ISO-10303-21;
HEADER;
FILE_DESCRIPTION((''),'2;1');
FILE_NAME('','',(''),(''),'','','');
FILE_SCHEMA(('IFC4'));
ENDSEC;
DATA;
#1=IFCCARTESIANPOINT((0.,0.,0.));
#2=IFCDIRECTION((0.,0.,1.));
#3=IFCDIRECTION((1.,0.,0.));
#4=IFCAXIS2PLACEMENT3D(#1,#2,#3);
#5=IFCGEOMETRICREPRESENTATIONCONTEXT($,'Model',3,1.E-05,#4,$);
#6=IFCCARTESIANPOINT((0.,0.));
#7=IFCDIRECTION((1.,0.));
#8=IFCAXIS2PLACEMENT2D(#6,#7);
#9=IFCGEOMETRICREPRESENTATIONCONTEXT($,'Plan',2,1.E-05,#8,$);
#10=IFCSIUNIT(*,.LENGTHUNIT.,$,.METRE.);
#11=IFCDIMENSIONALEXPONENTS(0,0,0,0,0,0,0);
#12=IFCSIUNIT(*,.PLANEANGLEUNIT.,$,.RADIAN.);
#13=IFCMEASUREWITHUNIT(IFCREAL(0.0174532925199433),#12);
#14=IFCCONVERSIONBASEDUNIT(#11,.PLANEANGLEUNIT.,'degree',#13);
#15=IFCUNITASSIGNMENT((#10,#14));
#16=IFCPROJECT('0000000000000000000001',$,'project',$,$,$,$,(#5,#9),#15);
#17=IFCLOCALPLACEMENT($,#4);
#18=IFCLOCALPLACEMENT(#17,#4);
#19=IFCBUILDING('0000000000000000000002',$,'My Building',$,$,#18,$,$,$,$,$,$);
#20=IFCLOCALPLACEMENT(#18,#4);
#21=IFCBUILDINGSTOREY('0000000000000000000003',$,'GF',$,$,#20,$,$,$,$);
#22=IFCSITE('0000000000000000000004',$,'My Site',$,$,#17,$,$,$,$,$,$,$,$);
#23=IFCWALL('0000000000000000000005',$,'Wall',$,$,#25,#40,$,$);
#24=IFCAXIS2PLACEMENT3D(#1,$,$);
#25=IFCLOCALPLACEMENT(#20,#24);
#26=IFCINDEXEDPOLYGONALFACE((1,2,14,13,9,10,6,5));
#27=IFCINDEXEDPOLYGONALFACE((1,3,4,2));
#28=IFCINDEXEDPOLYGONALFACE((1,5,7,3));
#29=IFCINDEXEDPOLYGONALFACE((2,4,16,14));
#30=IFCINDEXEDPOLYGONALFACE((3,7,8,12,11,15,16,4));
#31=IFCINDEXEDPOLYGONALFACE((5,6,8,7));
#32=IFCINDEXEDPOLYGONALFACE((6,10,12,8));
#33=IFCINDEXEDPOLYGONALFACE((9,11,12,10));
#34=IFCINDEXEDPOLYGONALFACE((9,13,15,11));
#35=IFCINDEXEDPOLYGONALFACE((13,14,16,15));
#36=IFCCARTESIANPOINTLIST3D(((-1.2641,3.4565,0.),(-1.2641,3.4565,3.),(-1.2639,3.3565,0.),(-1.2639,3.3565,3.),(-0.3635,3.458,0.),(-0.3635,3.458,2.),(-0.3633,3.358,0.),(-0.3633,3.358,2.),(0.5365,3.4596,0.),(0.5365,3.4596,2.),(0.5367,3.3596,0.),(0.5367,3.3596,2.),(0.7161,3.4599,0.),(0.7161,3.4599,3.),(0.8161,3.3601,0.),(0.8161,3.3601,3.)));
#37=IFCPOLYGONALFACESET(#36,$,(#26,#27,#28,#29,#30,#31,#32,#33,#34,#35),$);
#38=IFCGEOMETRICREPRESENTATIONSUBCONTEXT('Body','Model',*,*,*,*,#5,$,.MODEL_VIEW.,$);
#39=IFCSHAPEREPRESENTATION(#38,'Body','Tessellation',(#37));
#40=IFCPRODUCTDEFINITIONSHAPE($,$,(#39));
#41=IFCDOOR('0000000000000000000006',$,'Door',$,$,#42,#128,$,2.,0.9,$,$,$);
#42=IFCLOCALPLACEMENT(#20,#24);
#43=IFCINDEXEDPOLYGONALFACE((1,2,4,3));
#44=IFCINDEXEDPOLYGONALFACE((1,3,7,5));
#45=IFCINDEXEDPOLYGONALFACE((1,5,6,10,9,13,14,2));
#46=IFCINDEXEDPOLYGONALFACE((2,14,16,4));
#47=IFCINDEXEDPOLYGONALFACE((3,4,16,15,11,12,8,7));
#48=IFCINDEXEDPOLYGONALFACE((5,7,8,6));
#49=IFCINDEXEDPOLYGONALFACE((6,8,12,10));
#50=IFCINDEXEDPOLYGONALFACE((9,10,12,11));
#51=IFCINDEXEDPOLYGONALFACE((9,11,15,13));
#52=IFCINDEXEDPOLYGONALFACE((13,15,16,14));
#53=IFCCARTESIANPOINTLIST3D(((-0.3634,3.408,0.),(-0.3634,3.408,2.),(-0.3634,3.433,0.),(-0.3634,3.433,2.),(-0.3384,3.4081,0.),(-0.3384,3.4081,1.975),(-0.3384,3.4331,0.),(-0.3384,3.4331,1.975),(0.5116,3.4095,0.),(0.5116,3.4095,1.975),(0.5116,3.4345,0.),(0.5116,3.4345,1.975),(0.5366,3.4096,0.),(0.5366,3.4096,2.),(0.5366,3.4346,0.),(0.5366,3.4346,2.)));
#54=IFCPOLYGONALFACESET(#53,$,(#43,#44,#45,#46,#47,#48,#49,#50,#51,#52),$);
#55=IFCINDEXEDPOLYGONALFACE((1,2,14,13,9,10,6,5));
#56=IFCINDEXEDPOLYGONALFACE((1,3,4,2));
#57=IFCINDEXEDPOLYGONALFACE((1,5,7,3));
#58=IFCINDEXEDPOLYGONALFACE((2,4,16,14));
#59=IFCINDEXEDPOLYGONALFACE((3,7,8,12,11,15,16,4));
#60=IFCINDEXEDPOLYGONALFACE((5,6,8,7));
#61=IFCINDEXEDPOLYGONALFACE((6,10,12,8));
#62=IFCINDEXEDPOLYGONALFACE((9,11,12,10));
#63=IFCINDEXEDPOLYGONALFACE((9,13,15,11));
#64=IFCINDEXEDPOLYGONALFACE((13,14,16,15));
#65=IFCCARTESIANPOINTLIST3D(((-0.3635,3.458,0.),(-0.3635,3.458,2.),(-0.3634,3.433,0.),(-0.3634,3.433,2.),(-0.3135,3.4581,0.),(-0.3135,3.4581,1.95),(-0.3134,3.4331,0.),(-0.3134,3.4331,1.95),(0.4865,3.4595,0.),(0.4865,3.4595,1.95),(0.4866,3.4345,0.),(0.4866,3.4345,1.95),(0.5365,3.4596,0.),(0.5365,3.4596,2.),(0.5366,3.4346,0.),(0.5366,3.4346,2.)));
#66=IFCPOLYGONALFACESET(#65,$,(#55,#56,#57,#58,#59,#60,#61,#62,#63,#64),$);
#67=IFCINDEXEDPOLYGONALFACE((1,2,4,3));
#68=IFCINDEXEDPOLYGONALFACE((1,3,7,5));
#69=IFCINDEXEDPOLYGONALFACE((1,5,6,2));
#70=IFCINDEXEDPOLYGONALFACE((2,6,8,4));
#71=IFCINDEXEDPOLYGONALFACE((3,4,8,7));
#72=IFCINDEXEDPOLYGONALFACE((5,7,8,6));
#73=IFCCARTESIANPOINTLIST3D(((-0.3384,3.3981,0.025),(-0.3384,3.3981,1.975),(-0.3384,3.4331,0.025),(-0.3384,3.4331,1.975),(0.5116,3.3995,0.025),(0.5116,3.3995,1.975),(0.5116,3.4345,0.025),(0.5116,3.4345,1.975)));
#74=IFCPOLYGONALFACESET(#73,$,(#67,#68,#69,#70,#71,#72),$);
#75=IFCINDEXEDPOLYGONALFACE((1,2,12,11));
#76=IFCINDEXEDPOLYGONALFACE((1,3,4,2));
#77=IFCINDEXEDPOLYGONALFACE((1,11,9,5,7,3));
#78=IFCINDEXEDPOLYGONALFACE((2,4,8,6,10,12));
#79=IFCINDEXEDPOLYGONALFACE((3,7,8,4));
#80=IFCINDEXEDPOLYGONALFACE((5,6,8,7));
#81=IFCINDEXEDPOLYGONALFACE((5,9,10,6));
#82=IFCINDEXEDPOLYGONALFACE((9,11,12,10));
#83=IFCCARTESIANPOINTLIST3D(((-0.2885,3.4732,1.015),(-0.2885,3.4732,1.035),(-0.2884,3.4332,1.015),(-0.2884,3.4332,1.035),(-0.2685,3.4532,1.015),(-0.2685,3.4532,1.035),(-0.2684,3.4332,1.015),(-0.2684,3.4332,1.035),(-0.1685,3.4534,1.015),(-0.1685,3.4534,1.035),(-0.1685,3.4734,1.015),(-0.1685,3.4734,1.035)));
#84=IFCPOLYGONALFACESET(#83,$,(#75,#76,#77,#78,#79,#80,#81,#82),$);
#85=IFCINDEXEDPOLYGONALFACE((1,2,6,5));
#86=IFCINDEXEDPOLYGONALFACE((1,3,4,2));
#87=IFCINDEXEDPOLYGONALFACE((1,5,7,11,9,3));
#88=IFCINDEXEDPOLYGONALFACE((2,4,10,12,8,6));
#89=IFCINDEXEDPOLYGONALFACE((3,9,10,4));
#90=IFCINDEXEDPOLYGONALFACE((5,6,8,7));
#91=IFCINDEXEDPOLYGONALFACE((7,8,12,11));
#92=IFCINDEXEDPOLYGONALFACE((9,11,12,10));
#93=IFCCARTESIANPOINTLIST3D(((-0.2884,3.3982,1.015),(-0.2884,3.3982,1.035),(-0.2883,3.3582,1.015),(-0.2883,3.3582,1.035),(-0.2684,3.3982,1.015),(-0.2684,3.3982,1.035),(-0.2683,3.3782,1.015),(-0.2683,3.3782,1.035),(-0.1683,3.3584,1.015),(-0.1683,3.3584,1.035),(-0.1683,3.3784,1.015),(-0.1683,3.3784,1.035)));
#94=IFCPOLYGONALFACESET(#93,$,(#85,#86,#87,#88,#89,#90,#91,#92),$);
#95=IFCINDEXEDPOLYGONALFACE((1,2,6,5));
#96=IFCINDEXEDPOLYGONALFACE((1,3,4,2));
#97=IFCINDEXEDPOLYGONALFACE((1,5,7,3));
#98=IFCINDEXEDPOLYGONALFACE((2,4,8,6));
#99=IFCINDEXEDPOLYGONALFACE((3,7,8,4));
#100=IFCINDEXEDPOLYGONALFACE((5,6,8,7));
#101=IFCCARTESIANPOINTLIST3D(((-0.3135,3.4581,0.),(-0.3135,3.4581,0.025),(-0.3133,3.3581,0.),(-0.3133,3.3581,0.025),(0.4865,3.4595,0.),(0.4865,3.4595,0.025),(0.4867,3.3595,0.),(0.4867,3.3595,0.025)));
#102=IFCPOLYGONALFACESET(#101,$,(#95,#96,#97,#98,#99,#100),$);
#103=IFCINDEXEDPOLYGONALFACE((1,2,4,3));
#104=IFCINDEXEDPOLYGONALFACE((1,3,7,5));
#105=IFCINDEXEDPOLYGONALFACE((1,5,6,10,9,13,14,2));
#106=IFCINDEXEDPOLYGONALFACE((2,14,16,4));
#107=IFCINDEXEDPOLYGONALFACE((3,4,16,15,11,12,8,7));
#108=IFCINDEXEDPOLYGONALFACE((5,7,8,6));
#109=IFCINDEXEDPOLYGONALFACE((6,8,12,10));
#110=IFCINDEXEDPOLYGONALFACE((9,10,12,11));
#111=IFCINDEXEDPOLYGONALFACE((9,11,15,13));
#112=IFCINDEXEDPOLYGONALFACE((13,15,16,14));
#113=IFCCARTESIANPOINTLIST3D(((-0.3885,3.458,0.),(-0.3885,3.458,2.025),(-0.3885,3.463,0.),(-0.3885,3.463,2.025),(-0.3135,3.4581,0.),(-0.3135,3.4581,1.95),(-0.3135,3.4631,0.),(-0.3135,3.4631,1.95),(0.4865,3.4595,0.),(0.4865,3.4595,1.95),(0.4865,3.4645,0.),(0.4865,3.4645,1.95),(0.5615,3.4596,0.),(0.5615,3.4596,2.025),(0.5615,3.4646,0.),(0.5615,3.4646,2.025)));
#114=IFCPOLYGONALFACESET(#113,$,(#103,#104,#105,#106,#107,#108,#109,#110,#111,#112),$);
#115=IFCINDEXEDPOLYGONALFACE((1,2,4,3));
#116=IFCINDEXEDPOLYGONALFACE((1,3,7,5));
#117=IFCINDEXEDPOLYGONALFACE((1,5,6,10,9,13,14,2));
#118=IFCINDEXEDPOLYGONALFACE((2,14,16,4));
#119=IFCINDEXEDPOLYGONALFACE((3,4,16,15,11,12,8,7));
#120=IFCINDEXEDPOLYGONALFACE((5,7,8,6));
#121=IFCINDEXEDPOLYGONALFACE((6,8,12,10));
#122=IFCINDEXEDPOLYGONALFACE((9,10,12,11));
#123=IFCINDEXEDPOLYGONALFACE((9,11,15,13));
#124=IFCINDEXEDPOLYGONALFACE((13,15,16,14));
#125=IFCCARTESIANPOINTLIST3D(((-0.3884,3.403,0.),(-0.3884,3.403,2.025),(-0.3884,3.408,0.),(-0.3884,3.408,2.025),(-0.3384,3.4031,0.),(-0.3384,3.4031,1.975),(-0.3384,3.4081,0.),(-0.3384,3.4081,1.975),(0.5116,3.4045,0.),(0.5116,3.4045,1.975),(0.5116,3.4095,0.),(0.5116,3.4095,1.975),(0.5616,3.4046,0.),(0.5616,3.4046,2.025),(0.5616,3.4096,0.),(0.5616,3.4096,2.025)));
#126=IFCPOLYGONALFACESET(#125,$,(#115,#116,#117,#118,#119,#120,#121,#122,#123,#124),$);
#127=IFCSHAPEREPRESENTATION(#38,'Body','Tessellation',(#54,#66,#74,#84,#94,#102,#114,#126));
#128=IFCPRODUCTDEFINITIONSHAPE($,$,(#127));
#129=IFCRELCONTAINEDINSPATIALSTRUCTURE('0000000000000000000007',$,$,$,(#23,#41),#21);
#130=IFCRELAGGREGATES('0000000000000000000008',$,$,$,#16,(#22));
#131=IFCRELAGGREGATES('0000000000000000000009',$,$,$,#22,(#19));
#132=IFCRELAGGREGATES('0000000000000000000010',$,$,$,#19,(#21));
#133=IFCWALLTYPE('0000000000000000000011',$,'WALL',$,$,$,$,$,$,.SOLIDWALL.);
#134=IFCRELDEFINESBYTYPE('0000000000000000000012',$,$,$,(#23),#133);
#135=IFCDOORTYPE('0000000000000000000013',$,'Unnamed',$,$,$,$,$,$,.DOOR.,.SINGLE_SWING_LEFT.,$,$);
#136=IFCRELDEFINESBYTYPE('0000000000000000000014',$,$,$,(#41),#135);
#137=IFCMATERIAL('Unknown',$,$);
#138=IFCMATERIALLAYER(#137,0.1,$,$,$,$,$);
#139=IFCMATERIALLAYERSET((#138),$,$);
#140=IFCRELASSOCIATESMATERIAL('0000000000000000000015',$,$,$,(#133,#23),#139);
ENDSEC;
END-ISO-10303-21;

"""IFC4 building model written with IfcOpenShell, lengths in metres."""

from ifc_helpers import new_model, entity, si_unit, converted_unit, frame, origin_with_axes, origin_2d_with_axis, place, context, subcontext, project, spatial, line, indexed_curve, outline, extrude, shape, source, transform, mapped, material, layer, layer_set, layer_usage, type_object, type_shapes, element, fill, save


model = new_model("IFC4")

# Units and contexts
model_context = context("Model", 3, precision=1e-05, world=origin_with_axes())
plan_context = context("Plan", 2, precision=1e-05, world=origin_2d_with_axis())
body_context_1 = subcontext(model_context, "Body", "Model", "MODEL_VIEW")
body_context_2 = subcontext(plan_context, "Body", "Plan", "PLAN_VIEW")
ifc_project = project(units=[si_unit("LENGTHUNIT", "METRE"), converted_unit("PLANEANGLEUNIT", "degree", entity("IfcReal", 0.0174532925199433), si_unit("PLANEANGLEUNIT", "RADIAN"), dimensions=[0, 0, 0, 0, 0, 0, 0])], contexts=[model_context, plan_context])

# Site, building, storey
site_placement = place(None, origin_with_axes())
site = spatial("IfcSite", under=ifc_project, at=site_placement, Name="My Site")
building_placement = place(site_placement, origin_with_axes())
building = spatial("IfcBuilding", under=site, at=building_placement, Name="My Building")
storey_placement = place(building_placement, origin_with_axes())
storey = spatial("IfcBuildingStorey", under=building, at=storey_placement, Name="GF")

# Shared definitions
ifc_material = material(Name="Unknown")

# Shared definitions
ifc_layer_1 = layer(ifc_material, 0.1)
ifc_layer_set_1 = layer_set([ifc_layer_1])
wall_type = type_object("IfcWallType", Name="WALL", PredefinedType="SOLIDWALL", material=ifc_layer_set_1)
shared_shape_1 = source(origin_with_axes(), body_context_1, "Body", "SweptSolid", [
    extrude(outline(indexed_curve([(0.0, 0.0), (0.9, 0.0), (0.9, 2.0), (0.0, 2.0)], segments=[line(1, 2, 3, 4, 1)])), frame((0.0, -0.6, 0.0), z_axis=(0.0, -1.0, 0.0), x_axis=(1.0, 0.0, 0.0)), (0.0, 0.0, -1.0), 1.2),
])
door_type = type_object("IfcDoorType", Name="Unnamed", OperationType="SINGLE_SWING_LEFT", PredefinedType="DOOR")
shared_shape_2 = source(origin_with_axes(), body_context_1, "Body", "SweptSolid", [
    extrude(outline(indexed_curve([(0.0, 0.0), (0.0, 2.0), (0.9, 2.0), (0.9, 0.0), (0.875, 0.0), (0.875, 1.975), (0.025, 1.975), (0.025, 0.0)], segments=[line(1, 2, 3, 4, 5, 6, 7, 8, 1)])), frame((0.0, 0.025, 0.0), z_axis=(0.0, -1.0, 0.0), x_axis=(1.0, 0.0, 0.0)), (0.0, 0.0, -1.0), 0.025),
    extrude(outline(indexed_curve([(0.0, 0.0), (0.0, 2.0), (0.9, 2.0), (0.9, 0.0), (0.85, 0.0), (0.85, 1.95), (0.05, 1.95), (0.05, 0.0)], segments=[line(1, 2, 3, 4, 5, 6, 7, 8, 1)])), frame((0.0, 0.0, 0.0), z_axis=(0.0, -1.0, 0.0), x_axis=(1.0, 0.0, 0.0)), (0.0, 0.0, -1.0), 0.025),
    extrude(outline(indexed_curve([(0.0, 0.0), (0.85, 0.0), (0.85, 0.035), (0.0, 0.035)], segments=[line(1, 2, 3, 4, 1)])), frame((0.025, 0.025, 0.025), z_axis=(0.0, 0.0, 1.0), x_axis=(1.0, 0.0, 0.0)), (0.0, 0.0, 1.0), 1.95),
    extrude(outline(indexed_curve([(0.0, 0.0), (0.0, -0.04), (-0.12, -0.04), (-0.12, -0.02), (-0.02, -0.02), (-0.02, 0.0)], segments=[line(1, 2, 3, 4, 5, 6, 1)])), frame((0.825, 0.025, 1.015), z_axis=(0.0, 0.0, 1.0), x_axis=(1.0, 0.0, 0.0)), (0.0, 0.0, 1.0), 0.02),
    extrude(outline(indexed_curve([(0.0, 0.0), (0.0, 0.04), (-0.12, 0.04), (-0.12, 0.02), (-0.02, 0.02), (-0.02, 0.0)], segments=[line(1, 2, 3, 4, 5, 6, 1)])), frame((0.825, 0.06, 1.015), z_axis=(0.0, 0.0, 1.0), x_axis=(1.0, 0.0, 0.0)), (0.0, 0.0, 1.0), 0.02),
    extrude(outline(indexed_curve([(0.0, 0.0), (0.8, 0.0), (0.8, 0.1), (0.0, 0.1)], segments=[line(1, 2, 3, 4, 1)])), frame((0.05, 0.0, 0.0), z_axis=(0.0, 0.0, 1.0), x_axis=(1.0, 0.0, 0.0)), (0.0, 0.0, 1.0), 0.025),
    extrude(outline(indexed_curve([(0.0, 0.0), (0.0, 2.025), (0.95, 2.025), (0.95, 0.0), (0.875, 0.0), (0.875, 1.95), (0.075, 1.95), (0.075, 0.0)], segments=[line(1, 2, 3, 4, 5, 6, 7, 8, 1)])), frame((-0.025, -0.005, 0.0), z_axis=(0.0, -1.0, 0.0), x_axis=(1.0, 0.0, 0.0)), (0.0, 0.0, -1.0), 0.005),
    extrude(outline(indexed_curve([(0.0, 0.0), (0.0, 2.025), (0.95, 2.025), (0.95, 0.0), (0.9, 0.0), (0.9, 1.975), (0.05, 1.975), (0.05, 0.0)], segments=[line(1, 2, 3, 4, 5, 6, 7, 8, 1)])), frame((-0.025, 0.05, 0.0), z_axis=(0.0, -1.0, 0.0), x_axis=(1.0, 0.0, 0.0)), (0.0, 0.0, -1.0), 0.005),
])
shared_shape_3 = source(origin_with_axes(), body_context_2, "Body", "Curve2D", [
    entity("IfcIndexedPolyCurve", entity("IfcCartesianPointList2D", [[0.0, 0.0], [0.0, 0.05], [0.025, 0.05], [0.025, 0.025], [0.05, 0.025], [0.05, 0.0]]), [entity("IfcLineIndex", [1, 2, 3, 4, 5, 6, 1])]),
    entity("IfcIndexedPolyCurve", entity("IfcCartesianPointList2D", [[0.9, 0.0], [0.9, 0.05], [0.875, 0.05], [0.875, 0.025], [0.85, 0.025], [0.85, 0.0]]), [entity("IfcLineIndex", [1, 2, 3, 4, 5, 6, 1])]),
    entity("IfcTrimmedCurve", entity("IfcEllipse", entity("IfcAxis2Placement2D", entity("IfcCartesianPoint", [0.06, 0.05]), entity("IfcDirection", [1.0, 0.0])), 0.815, 0.85), [entity("IfcCartesianPoint", [0.875, 0.05])], [entity("IfcCartesianPoint", [0.06, 0.9])], True, "CARTESIAN"),
    entity("IfcIndexedPolyCurve", entity("IfcCartesianPointList2D", [[0.025, 0.05], [0.06, 0.05], [0.06, 0.9], [0.025, 0.9]]), [entity("IfcLineIndex", [1, 2, 3, 4, 1])]),
])
type_shapes(door_type, [shared_shape_2, shared_shape_3])

# Wall, opening, door
ifc_layer_usage_1 = layer_usage(ifc_layer_set_1, "AXIS2", "POSITIVE", 0.0)
wall_1_placement = place(storey_placement, frame((0.7161, 3.4599, 0.0), z_axis=(0.0, 0.0, 1.0), x_axis=(-0.999999, -0.00173, 0.0)))
wall_1 = element("IfcWall", 1, at=wall_1_placement, inside=storey, type_object=wall_type, material=ifc_layer_usage_1, Name="Wall", context=body_context_1, shape_type="SweptSolid", body=[
    extrude(outline(indexed_curve([(0.0, 0.0), (-0.0998, 0.1), (1.9802, 0.1), (1.9802, 0.0)], segments=[line(1, 2, 3, 4, 1)])), origin_with_axes(), (0.0, 0.0, 1.0), 3.0),
])
opening_1_placement = place(wall_1_placement, frame((0.1796, 0.0, 0.0), z_axis=(0.0, 0.0, 1.0), x_axis=(1.0, 0.0, 0.0)))
opening_1 = element("IfcOpeningElement", 2, at=opening_1_placement, cuts=wall_1, PredefinedType="OPENING", context=body_context_1, shape_type="MappedRepresentation", body=[
    mapped(shared_shape_1, transform((0.0, 0.0, 0.0), x_axis=(1.0, 0.0, 0.0), y_axis=(0.0, 1.0, 0.0), z_axis=(0.0, 0.0, 1.0), scale=1.0)),
])
door_1_placement = place(opening_1_placement, frame((0.0, 0.0, 0.0), z_axis=(0.0, 0.0, 1.0), x_axis=(1.0, 0.0, 0.0)))
door_1 = element("IfcDoor", 3, at=door_1_placement, inside=storey, type_object=door_type, Name="Door", OverallHeight=2.0, OverallWidth=0.9, shapes=[
    shape(body_context_1, "Body", "MappedRepresentation", [mapped(shared_shape_2, transform((0.0, 0.0, 0.0), x_axis=(1.0, 0.0, 0.0), y_axis=(0.0, 1.0, 0.0), z_axis=(0.0, 0.0, 1.0), scale=1.0))]),
    shape(body_context_2, "Body", "MappedRepresentation", [mapped(shared_shape_3, transform((0.0, 0.0, 0.0), x_axis=(1.0, 0.0, 0.0), y_axis=(0.0, 1.0, 0.0), z_axis=(0.0, 0.0, 1.0), scale=1.0))]),
])
fill(opening_1, door_1)

save(model, "model.ifc")
